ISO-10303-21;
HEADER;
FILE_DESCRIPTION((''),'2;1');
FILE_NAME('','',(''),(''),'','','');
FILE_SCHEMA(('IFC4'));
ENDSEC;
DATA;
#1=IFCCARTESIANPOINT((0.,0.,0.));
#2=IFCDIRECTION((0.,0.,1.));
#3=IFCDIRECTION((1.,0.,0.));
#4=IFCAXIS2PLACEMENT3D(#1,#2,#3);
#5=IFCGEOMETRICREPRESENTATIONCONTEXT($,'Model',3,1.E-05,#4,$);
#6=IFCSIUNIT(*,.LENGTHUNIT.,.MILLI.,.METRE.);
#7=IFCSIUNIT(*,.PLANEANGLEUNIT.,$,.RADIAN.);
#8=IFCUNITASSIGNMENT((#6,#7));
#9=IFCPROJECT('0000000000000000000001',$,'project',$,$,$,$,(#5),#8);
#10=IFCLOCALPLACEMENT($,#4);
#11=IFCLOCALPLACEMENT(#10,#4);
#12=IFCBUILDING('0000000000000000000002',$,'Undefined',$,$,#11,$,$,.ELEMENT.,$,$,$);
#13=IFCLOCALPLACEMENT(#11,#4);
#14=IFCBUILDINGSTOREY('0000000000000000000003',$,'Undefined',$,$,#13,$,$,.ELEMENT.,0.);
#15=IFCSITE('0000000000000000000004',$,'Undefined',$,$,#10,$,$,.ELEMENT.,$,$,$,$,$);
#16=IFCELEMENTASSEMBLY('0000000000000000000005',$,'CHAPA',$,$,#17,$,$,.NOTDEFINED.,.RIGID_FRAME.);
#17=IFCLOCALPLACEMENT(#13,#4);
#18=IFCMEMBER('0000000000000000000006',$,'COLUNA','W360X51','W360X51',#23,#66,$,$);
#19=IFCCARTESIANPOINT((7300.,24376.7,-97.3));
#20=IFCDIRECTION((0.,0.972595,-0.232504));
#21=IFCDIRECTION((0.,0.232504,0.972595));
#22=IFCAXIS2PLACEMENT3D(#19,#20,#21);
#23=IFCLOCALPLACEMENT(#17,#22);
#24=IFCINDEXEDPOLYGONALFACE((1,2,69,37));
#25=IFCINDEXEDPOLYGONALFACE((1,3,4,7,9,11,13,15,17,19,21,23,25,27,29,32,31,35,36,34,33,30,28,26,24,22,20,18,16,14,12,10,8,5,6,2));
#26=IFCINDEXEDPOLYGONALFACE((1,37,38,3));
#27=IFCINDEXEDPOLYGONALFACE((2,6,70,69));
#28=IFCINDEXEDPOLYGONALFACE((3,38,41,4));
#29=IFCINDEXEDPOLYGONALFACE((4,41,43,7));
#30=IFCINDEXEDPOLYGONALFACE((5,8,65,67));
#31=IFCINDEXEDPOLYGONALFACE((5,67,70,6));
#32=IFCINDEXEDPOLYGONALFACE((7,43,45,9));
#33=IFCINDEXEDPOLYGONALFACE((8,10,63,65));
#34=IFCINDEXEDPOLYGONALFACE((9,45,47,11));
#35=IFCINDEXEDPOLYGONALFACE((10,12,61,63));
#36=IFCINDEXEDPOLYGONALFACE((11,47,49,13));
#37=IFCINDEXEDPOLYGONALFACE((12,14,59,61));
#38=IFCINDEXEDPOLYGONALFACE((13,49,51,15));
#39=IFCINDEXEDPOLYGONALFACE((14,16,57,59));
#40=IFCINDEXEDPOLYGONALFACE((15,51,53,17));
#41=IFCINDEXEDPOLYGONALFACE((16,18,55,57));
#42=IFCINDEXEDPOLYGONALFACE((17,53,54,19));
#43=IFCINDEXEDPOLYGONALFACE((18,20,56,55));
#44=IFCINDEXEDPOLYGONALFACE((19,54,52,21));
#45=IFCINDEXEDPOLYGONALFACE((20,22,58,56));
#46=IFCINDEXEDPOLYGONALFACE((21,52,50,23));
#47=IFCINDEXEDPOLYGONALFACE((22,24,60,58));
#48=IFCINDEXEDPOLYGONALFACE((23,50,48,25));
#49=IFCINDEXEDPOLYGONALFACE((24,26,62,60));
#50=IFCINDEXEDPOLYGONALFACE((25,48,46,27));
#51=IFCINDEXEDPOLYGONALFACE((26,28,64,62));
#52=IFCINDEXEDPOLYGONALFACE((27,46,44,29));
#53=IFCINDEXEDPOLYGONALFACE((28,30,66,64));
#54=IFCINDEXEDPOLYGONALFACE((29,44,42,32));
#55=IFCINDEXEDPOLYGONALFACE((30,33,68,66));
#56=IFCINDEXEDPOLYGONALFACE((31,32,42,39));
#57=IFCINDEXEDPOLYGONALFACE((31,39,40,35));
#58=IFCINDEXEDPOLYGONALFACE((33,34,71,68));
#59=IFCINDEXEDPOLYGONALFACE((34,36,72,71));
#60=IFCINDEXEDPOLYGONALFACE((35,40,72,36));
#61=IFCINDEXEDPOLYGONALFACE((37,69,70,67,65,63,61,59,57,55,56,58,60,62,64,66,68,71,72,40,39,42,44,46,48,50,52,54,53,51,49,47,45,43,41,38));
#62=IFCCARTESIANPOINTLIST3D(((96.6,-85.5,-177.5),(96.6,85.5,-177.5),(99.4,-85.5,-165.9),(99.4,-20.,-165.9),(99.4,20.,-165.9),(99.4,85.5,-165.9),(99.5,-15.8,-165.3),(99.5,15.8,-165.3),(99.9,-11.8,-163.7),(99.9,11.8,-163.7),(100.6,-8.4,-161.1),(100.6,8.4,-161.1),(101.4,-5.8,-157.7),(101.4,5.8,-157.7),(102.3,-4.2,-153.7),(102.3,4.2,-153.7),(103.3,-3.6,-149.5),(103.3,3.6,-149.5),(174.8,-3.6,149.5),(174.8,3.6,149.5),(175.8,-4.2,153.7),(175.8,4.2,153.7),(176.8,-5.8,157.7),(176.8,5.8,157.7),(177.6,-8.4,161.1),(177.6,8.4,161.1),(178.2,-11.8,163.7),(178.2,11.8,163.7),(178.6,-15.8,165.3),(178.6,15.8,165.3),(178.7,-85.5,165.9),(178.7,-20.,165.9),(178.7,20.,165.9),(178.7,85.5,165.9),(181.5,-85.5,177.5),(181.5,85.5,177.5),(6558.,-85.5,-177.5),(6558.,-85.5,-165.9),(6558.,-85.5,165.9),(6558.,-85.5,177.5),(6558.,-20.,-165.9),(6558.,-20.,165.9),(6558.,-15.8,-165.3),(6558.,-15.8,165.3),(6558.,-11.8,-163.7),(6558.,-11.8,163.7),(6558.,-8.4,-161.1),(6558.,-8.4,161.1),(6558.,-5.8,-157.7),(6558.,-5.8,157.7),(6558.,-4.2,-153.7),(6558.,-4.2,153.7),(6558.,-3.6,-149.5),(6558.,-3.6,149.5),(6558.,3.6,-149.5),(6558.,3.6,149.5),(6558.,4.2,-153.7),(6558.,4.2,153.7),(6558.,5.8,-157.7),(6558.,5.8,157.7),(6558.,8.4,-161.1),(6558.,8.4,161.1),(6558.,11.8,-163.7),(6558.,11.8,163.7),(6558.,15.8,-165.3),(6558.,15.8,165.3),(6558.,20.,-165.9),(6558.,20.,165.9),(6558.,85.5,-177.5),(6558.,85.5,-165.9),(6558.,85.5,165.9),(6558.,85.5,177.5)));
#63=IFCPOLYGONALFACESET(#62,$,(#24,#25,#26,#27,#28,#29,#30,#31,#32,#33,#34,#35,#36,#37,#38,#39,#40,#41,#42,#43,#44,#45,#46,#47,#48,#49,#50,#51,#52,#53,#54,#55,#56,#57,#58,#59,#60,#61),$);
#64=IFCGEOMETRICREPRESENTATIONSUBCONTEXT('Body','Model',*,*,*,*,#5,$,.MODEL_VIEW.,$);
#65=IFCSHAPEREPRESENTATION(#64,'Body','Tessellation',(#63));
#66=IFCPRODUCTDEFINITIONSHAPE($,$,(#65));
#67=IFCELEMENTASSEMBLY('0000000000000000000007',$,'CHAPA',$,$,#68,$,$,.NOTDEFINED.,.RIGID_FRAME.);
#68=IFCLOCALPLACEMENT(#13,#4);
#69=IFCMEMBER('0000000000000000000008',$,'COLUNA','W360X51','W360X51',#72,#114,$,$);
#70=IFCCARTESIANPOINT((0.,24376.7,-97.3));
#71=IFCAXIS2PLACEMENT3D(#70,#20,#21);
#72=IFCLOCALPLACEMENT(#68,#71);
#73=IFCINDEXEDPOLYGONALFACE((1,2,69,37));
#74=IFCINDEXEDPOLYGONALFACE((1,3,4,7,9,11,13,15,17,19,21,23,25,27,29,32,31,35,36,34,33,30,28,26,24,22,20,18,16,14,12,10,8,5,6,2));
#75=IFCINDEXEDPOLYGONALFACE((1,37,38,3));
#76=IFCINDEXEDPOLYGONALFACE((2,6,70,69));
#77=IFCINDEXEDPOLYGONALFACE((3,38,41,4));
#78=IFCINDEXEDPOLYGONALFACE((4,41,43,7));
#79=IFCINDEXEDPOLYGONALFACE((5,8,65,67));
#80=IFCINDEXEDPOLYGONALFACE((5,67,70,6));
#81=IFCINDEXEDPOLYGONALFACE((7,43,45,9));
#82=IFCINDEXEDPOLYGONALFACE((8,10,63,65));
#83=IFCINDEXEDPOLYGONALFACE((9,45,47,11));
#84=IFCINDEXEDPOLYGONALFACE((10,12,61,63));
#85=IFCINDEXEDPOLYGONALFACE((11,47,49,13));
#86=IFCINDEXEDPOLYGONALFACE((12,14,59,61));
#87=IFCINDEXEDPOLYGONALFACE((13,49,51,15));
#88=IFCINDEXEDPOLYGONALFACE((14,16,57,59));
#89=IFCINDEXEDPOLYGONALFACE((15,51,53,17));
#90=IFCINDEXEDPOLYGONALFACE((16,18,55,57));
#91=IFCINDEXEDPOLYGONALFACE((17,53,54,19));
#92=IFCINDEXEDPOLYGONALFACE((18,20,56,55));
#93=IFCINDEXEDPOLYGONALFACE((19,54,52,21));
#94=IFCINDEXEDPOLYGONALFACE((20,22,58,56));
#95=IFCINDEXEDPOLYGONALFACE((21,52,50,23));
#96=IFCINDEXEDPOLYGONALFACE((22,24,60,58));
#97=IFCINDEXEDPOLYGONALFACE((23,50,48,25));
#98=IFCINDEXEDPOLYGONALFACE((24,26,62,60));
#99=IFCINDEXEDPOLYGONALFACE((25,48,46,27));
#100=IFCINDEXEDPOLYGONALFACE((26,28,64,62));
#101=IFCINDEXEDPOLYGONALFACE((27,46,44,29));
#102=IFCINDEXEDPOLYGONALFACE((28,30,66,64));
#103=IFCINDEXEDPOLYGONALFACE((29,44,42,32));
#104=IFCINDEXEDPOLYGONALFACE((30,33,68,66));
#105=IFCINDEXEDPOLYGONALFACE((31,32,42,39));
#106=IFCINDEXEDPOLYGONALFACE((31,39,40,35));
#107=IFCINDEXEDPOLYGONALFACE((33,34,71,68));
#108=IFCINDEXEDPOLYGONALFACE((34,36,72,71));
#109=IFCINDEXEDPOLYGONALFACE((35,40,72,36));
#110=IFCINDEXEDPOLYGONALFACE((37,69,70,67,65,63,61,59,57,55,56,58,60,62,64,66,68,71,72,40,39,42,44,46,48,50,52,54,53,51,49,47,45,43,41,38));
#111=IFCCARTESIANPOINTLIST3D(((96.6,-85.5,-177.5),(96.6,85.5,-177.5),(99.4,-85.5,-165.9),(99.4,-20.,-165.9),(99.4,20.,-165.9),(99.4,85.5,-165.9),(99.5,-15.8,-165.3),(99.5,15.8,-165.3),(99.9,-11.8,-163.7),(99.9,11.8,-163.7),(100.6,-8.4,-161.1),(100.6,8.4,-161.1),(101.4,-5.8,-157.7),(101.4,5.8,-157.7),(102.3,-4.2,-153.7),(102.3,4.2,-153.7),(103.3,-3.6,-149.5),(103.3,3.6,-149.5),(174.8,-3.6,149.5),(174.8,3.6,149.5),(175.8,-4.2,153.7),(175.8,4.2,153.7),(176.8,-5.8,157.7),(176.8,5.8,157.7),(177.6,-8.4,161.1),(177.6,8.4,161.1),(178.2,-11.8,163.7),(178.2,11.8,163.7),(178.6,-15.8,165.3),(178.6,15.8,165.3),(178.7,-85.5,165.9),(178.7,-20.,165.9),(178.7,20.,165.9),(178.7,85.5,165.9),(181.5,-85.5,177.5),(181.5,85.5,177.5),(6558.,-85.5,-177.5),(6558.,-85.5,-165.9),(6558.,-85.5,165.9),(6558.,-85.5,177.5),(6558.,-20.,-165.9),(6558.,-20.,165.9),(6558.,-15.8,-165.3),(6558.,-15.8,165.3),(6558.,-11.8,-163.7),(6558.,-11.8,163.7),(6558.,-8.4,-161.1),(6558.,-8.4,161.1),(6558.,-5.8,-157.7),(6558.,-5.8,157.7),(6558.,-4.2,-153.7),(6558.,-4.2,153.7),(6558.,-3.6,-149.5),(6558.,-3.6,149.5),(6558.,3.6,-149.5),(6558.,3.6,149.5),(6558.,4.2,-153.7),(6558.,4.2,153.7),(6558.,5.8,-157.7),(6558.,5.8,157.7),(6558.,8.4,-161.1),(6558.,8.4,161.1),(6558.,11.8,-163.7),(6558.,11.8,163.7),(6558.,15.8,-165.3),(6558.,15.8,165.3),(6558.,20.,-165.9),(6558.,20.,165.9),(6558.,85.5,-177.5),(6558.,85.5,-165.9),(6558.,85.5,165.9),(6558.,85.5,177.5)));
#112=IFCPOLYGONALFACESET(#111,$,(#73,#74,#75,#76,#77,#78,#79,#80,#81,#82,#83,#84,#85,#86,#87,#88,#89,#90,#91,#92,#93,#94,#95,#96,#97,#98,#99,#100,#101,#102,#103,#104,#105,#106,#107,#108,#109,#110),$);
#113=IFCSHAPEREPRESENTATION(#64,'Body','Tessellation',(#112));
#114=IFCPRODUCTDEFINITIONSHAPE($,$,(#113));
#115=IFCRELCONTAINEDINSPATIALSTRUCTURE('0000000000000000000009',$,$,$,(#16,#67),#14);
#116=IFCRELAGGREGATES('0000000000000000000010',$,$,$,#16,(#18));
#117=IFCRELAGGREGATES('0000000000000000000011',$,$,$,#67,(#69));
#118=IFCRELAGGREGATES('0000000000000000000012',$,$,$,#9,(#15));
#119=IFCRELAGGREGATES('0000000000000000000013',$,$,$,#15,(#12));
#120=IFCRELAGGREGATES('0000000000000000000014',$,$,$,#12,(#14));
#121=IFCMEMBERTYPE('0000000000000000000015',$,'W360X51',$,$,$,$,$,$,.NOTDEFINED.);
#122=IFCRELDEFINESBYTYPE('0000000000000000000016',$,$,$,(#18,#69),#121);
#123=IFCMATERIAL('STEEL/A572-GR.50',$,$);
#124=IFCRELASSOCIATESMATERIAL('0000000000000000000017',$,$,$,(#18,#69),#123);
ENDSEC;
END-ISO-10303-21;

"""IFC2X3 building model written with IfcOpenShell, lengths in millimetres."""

from ifc_helpers import new_model, si_unit, frame, origin_with_axes, origin_2d_with_axis, place, context, subcontext, project, spatial, i_section, extrude, clip, halfspace, material, type_object, element, aggregate, save


model = new_model("IFC2X3")

# Units and contexts
model_context = context("Model", 3, precision=1e-05, world=origin_with_axes())
body_context = subcontext(model_context, "Body", "Model", "MODEL_VIEW")
ifc_project = project(units=[si_unit("LENGTHUNIT", "METRE", prefix="MILLI"), si_unit("PLANEANGLEUNIT", "RADIAN")], contexts=[model_context])

# Site, building, storey
site_placement = place(None, origin_with_axes())
site = spatial("IfcSite", under=ifc_project, at=site_placement, Name="Undefined", CompositionType="ELEMENT")
building_placement = place(site_placement, origin_with_axes())
building = spatial("IfcBuilding", under=site, at=building_placement, Name="Undefined", CompositionType="ELEMENT")
storey_placement = place(building_placement, origin_with_axes())
storey = spatial("IfcBuildingStorey", under=building, at=storey_placement, Name="Undefined", CompositionType="ELEMENT", Elevation=0.0)

# Element assemblies, members
assembly_1_placement = place(storey_placement, origin_with_axes())
assembly_1 = element("IfcElementAssembly", 1, at=assembly_1_placement, inside=storey, Name="CHAPA", AssemblyPlace="NOTDEFINED", PredefinedType="RIGID_FRAME")
ifc_material_1 = material(Name="STEEL/A572-GR.50")
member_type = type_object("IfcMemberType", Name="W360X51", PredefinedType="NOTDEFINED")
member_1_placement = place(assembly_1_placement, frame((7300.0, 24376.7, -97.3), z_axis=(0.0, 0.972595, -0.232504), x_axis=(0.0, 0.232504, 0.972595)))
member_1 = element("IfcMember", 2, at=member_1_placement, type_object=member_type, material=ifc_material_1, Name="COLUNA", Description="W360X51", ObjectType="W360X51", context=body_context, shape_type="Clipping", body=[
    clip(clip(extrude(i_section(OverallWidth=171.0, OverallDepth=355.0, WebThickness=7.2, FlangeThickness=11.6, FilletRadius=16.4, at=origin_2d_with_axis()), frame((6558.0, 0.0, 0.0), z_axis=(-1.0, 0.0, 0.0), x_axis=(0.0, -1.0, 0.0)), (0.0, 0.0, 1.0), 6542.9), halfspace(frame((94.5, -85.5, -186.3), z_axis=(-0.972595, 0.0, 0.232504), x_axis=(0.0, 1.0, 0.0)), False)), halfspace(frame((96.6, 0.0, -177.5), z_axis=(0.972595, 0.0, -0.232504), x_axis=(0.0, -1.0, 0.0)), True)),
])
assembly_2_placement = place(storey_placement, origin_with_axes())
assembly_2 = element("IfcElementAssembly", 3, at=assembly_2_placement, inside=storey, Name="CHAPA", AssemblyPlace="NOTDEFINED", PredefinedType="RIGID_FRAME")
member_2_placement = place(assembly_2_placement, frame((0.0, 24376.7, -97.3), z_axis=(0.0, 0.972595, -0.232504), x_axis=(0.0, 0.232504, 0.972595)))
member_2 = element("IfcMember", 4, at=member_2_placement, type_object=member_type, material=ifc_material_1, Name="COLUNA", Description="W360X51", ObjectType="W360X51", context=body_context, shape_type="Clipping", body=[
    clip(clip(extrude(i_section(OverallWidth=171.0, OverallDepth=355.0, WebThickness=7.2, FlangeThickness=11.6, FilletRadius=16.4, at=origin_2d_with_axis()), frame((6558.0, 0.0, 0.0), z_axis=(-1.0, 0.0, 0.0), x_axis=(0.0, -1.0, 0.0)), (0.0, 0.0, 1.0), 6542.9), halfspace(frame((94.5, -85.5, -186.3), z_axis=(-0.972595, 0.0, 0.232504), x_axis=(0.0, 1.0, 0.0)), False)), halfspace(frame((96.6, 0.0, -177.5), z_axis=(0.972595, 0.0, -0.232504), x_axis=(0.0, -1.0, 0.0)), True)),
])

aggregate(assembly_1, [member_1])
aggregate(assembly_2, [member_2])

save(model, "model.ifc")
